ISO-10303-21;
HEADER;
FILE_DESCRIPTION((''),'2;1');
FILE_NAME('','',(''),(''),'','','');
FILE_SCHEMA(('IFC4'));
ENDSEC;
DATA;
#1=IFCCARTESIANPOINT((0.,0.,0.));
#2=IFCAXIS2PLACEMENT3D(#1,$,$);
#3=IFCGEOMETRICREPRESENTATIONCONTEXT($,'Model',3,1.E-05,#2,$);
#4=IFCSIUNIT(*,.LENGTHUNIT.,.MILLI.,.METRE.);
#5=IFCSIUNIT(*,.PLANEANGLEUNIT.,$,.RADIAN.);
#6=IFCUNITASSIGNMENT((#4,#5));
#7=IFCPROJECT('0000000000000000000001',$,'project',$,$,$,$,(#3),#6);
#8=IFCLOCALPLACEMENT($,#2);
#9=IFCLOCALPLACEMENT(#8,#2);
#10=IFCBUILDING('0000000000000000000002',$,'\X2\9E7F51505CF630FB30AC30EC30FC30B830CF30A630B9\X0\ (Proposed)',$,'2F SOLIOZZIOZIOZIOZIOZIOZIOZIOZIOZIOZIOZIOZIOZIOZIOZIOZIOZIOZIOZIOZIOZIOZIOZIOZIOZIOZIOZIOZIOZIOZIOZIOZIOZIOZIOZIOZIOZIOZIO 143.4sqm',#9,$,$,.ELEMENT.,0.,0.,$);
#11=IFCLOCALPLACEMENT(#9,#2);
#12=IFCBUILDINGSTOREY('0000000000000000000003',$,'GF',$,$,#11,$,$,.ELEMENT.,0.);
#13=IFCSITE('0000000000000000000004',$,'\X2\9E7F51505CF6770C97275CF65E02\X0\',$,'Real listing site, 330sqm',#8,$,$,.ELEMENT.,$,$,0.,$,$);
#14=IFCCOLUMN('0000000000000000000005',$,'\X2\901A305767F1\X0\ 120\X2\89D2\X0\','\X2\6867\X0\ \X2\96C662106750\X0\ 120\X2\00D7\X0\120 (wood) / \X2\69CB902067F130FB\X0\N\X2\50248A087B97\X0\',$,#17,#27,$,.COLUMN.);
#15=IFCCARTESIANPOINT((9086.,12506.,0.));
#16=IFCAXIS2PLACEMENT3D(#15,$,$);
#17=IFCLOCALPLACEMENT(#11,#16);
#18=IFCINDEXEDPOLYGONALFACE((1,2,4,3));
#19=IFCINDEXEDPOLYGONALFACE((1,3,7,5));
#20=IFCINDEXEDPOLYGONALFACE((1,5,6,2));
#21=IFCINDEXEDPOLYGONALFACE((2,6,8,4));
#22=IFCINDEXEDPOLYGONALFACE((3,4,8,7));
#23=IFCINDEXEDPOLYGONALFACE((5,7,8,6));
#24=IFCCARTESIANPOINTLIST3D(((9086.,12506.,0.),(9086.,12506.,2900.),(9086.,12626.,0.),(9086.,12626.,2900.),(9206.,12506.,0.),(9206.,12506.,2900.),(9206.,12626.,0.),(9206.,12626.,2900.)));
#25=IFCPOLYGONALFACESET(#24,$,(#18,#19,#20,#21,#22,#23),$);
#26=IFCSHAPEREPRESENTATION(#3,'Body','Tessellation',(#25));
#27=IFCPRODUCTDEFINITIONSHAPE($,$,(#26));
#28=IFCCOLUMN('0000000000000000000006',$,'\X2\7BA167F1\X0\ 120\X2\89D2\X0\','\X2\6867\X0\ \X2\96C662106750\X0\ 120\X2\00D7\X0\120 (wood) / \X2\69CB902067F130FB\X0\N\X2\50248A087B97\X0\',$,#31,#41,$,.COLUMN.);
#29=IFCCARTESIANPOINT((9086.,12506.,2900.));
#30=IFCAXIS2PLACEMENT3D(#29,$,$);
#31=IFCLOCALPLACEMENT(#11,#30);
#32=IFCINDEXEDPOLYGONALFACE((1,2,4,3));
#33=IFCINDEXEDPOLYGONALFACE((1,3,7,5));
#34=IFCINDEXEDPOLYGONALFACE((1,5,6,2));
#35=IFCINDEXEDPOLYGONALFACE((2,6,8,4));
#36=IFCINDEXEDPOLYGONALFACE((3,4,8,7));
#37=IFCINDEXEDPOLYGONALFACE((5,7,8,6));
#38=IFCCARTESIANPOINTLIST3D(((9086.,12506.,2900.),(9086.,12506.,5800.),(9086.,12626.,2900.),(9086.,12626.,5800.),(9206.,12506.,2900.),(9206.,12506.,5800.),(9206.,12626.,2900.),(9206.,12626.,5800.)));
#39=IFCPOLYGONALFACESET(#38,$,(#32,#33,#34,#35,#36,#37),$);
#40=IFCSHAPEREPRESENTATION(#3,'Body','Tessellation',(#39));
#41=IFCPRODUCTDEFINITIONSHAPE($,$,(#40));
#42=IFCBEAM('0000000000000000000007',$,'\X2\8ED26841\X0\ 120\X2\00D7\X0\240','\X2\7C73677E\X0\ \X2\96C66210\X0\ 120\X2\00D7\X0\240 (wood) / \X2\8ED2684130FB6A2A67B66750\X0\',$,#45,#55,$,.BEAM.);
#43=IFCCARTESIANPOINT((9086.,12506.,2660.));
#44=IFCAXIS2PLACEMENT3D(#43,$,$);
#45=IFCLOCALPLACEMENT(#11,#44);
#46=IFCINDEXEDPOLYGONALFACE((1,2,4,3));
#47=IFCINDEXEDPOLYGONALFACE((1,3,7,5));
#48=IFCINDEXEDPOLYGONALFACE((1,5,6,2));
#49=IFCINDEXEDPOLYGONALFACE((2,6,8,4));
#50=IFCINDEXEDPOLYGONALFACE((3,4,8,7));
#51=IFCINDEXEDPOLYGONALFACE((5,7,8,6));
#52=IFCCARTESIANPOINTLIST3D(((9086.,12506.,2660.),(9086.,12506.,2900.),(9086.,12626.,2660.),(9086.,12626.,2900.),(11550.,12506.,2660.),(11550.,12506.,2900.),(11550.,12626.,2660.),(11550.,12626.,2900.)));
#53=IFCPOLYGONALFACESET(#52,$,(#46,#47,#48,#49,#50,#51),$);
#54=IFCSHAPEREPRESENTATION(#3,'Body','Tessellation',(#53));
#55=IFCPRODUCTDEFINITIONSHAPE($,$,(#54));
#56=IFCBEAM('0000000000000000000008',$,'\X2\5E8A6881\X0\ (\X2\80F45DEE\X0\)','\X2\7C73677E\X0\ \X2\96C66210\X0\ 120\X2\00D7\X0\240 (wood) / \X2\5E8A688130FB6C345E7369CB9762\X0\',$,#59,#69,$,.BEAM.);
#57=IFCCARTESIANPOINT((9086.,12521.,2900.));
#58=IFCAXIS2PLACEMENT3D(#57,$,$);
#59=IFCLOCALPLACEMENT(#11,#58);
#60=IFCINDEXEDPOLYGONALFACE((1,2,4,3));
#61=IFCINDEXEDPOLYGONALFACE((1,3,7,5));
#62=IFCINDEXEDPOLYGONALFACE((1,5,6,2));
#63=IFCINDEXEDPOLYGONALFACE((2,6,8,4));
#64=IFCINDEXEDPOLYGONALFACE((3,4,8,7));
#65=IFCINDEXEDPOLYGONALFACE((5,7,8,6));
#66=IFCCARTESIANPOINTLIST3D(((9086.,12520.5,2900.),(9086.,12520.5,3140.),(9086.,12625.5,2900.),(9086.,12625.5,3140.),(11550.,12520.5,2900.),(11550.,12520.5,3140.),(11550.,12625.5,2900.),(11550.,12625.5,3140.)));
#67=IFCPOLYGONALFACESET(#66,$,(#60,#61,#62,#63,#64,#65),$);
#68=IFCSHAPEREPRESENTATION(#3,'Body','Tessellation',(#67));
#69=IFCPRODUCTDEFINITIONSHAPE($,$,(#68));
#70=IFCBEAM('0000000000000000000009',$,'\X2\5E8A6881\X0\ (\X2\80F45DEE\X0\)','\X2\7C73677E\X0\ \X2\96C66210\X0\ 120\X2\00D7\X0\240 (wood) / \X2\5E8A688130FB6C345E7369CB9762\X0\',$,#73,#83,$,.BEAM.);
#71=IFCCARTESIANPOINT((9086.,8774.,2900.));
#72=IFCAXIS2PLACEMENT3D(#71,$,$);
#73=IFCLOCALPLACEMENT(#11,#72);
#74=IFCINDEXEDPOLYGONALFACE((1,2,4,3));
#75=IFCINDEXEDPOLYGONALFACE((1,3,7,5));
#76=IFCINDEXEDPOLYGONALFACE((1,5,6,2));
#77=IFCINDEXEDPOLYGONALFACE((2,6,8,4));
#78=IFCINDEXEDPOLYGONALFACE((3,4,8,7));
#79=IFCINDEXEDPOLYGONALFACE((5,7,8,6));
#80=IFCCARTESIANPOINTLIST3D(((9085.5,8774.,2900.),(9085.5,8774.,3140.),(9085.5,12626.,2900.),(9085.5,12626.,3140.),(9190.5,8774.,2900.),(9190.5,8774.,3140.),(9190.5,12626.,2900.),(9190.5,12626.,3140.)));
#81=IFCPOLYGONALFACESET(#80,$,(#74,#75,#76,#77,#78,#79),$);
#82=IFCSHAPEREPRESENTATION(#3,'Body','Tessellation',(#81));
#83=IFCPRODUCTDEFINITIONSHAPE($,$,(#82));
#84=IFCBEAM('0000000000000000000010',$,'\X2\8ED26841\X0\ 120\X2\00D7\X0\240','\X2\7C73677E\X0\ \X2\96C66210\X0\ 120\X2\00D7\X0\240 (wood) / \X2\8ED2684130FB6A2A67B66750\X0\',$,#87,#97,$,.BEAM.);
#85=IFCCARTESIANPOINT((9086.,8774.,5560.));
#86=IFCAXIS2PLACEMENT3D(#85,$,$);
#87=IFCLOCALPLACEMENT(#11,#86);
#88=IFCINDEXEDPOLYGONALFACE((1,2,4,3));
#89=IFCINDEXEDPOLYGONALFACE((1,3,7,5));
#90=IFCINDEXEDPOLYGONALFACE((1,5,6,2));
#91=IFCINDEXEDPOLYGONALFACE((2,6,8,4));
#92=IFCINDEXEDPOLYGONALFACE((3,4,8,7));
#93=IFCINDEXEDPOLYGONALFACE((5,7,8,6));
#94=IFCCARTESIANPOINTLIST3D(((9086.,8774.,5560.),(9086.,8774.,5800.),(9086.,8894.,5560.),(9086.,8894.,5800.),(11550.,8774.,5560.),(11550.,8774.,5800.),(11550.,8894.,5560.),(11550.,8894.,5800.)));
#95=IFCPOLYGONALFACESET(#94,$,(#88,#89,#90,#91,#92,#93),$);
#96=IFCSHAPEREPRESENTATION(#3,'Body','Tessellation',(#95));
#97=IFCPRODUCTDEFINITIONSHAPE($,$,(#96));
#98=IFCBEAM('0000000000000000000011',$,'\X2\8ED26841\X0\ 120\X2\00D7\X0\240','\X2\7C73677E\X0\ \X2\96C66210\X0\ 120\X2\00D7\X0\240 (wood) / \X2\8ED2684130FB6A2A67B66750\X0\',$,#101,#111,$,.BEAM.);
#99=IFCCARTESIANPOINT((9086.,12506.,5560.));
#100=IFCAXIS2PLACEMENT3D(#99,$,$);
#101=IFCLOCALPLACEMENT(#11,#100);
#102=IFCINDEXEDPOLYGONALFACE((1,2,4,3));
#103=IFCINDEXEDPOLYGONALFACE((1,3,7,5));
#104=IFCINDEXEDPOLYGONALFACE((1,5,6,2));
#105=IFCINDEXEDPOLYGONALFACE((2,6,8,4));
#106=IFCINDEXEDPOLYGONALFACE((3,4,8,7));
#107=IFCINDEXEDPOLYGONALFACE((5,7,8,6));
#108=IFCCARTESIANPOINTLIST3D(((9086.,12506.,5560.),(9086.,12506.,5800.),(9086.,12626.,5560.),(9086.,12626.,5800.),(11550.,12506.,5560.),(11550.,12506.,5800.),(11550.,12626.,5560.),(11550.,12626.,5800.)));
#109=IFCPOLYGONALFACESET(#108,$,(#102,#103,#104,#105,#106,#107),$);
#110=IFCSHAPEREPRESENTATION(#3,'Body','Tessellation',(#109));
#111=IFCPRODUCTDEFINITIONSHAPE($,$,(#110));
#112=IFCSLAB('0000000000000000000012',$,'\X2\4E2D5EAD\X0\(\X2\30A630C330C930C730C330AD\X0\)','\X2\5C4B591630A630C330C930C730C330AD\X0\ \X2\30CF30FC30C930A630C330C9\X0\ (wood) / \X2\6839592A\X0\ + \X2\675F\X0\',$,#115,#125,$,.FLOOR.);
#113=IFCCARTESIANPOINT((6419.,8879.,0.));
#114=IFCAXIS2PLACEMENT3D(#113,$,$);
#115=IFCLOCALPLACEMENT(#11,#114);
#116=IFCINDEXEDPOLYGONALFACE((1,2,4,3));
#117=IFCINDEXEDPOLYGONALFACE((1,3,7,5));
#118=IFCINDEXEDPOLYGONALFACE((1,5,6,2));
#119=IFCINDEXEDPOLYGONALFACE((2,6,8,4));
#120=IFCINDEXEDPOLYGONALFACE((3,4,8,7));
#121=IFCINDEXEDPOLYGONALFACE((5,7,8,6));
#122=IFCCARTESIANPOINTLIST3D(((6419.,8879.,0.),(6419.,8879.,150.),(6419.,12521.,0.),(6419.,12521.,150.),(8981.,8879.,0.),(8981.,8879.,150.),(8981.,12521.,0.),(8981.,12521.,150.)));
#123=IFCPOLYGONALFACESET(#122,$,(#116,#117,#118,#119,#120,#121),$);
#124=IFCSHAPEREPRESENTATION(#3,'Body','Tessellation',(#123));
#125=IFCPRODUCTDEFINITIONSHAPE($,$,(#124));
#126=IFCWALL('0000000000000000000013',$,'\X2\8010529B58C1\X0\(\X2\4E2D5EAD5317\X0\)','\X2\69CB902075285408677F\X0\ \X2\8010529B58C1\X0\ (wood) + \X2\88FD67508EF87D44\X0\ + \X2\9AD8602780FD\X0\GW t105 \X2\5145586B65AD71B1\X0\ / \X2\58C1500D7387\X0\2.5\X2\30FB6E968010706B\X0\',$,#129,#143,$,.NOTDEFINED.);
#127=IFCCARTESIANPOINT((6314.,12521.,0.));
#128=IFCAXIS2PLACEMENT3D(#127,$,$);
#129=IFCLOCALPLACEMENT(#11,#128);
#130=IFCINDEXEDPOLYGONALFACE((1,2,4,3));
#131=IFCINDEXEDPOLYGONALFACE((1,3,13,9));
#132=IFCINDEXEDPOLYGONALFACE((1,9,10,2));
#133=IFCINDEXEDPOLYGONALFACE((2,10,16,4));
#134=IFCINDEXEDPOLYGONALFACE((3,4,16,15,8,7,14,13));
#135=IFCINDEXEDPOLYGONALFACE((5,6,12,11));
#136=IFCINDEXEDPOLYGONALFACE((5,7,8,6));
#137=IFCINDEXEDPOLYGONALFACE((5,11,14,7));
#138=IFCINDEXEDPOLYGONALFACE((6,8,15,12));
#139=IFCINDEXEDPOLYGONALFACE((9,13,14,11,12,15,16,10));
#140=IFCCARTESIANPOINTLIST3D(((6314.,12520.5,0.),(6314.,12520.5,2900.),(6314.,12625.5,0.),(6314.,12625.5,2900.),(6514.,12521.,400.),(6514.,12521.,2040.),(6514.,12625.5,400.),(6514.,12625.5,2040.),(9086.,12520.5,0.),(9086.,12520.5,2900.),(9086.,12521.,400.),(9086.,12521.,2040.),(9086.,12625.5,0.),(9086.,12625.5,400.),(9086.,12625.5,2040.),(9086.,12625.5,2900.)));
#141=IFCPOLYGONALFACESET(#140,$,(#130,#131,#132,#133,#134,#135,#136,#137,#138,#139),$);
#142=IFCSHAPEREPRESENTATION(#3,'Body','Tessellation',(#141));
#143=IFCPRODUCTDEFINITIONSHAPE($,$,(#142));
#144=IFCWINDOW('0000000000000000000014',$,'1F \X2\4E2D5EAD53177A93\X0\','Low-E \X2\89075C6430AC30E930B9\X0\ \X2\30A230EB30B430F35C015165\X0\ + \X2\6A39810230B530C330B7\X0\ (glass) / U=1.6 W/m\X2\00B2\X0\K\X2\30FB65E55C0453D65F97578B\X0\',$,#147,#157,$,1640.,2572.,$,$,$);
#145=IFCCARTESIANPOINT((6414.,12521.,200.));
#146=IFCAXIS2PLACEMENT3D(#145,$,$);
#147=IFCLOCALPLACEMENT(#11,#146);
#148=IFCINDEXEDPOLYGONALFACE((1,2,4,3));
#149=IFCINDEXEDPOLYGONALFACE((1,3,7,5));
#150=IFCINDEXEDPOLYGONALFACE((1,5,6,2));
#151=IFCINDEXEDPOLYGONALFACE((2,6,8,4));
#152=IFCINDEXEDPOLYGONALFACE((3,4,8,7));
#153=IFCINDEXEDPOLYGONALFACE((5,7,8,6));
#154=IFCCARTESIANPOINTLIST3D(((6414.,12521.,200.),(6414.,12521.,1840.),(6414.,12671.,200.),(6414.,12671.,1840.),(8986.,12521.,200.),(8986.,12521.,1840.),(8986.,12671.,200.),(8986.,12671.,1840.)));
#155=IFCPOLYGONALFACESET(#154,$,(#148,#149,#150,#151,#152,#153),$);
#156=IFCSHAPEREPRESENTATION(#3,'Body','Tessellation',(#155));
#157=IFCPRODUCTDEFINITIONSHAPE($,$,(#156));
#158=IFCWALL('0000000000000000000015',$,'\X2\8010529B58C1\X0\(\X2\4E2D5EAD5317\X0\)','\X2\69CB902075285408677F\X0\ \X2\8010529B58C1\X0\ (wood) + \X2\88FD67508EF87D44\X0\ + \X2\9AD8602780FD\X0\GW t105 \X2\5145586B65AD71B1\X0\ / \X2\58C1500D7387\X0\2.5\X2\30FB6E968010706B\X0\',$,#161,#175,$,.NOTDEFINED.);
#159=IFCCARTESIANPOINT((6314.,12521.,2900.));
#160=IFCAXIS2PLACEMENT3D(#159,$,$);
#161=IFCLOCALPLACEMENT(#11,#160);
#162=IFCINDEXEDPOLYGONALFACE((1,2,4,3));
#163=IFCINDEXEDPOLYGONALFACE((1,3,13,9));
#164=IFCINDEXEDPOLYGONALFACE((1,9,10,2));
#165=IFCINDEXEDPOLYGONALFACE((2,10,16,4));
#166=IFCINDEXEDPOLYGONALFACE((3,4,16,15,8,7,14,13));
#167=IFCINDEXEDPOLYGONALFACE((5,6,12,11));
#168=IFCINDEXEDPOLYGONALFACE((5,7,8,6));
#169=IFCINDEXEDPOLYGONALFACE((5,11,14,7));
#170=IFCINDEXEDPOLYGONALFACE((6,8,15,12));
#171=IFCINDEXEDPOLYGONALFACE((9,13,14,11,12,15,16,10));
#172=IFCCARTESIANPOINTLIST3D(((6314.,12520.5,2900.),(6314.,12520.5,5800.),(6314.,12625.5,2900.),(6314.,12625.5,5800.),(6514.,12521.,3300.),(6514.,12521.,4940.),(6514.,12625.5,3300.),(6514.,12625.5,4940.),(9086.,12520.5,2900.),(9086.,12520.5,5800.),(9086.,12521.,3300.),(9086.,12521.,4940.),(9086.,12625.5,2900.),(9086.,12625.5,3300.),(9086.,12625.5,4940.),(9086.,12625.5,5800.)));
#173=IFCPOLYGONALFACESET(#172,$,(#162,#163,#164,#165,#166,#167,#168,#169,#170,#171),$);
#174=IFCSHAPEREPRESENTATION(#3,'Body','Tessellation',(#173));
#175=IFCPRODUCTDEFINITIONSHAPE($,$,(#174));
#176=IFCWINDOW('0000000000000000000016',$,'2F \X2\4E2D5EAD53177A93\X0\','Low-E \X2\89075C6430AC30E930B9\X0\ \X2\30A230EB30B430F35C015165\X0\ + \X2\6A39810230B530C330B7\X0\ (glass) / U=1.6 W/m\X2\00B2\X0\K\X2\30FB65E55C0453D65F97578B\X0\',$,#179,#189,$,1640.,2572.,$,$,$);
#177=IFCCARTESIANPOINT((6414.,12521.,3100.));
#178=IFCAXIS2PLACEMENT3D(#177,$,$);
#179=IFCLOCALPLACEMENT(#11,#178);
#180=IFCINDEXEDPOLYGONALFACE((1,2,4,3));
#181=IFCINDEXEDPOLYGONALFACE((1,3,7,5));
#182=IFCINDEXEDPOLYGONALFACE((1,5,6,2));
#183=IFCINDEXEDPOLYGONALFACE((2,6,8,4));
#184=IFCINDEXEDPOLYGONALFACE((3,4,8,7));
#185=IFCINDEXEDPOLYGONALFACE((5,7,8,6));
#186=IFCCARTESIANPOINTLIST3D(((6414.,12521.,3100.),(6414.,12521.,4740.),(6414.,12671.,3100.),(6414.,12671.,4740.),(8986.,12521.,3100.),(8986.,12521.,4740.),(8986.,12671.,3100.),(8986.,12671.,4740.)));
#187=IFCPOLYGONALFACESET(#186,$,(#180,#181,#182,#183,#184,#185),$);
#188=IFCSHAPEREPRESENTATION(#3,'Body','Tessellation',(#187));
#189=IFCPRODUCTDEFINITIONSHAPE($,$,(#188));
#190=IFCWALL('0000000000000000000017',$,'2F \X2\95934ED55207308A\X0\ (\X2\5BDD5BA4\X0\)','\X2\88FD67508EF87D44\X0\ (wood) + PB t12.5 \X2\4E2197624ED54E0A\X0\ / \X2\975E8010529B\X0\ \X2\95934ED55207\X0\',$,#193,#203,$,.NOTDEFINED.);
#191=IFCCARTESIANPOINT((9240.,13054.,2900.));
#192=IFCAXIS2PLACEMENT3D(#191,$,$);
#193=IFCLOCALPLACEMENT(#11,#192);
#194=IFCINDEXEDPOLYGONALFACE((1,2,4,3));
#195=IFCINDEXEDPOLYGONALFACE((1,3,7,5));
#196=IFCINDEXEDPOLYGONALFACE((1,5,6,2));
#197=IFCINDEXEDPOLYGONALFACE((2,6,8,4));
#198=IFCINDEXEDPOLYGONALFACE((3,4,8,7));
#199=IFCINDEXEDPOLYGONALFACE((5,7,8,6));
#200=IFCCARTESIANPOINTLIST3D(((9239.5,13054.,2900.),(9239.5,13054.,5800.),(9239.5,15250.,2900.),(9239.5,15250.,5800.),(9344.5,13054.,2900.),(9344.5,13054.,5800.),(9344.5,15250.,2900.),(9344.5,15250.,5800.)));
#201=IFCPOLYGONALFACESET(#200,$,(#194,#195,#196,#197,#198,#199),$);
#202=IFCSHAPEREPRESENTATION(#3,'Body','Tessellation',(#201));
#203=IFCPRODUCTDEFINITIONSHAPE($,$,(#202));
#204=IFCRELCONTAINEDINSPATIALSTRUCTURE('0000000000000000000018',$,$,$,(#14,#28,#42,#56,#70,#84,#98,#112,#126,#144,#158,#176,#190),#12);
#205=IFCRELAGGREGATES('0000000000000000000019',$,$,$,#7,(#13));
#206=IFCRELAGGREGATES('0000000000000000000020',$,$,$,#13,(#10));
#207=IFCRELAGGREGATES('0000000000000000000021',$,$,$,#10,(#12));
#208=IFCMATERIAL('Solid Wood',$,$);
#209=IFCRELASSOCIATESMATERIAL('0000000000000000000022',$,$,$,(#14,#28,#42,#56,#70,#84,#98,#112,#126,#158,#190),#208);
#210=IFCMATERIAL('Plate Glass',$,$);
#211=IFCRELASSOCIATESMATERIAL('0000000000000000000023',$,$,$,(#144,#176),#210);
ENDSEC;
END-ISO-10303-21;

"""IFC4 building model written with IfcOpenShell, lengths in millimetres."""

from ifc_helpers import new_model, si_unit, frame, frame_2d, origin, place, context, project, spatial, rectangle, extrude, material, element, fill, save


model = new_model("IFC4")

# Units and contexts
model_context = context("Model", 3, precision=1e-05, world=origin())
ifc_project = project(units=[si_unit("LENGTHUNIT", "METRE", prefix="MILLI"), si_unit("PLANEANGLEUNIT", "RADIAN")], contexts=[model_context])

# Site, building, storey
site_placement = place(None, origin())
site = spatial("IfcSite", under=ifc_project, at=site_placement, Name="鹿児島県霧島市", ObjectType="Real listing site, 330sqm", CompositionType="ELEMENT", RefElevation=0.0)
building_placement = place(site_placement, origin())
building = spatial("IfcBuilding", under=site, at=building_placement, Name="鹿児島・ガレージハウス (Proposed)", ObjectType="2F SOLIOZZIOZIOZIOZIOZIOZIOZIOZIOZIOZIOZIOZIOZIOZIOZIOZIOZIOZIOZIOZIOZIOZIOZIOZIOZIOZIOZIOZIOZIOZIOZIOZIOZIOZIOZIOZIOZIOZIO 143.4sqm", CompositionType="ELEMENT", ElevationOfRefHeight=0.0, ElevationOfTerrain=0.0)
storey_placement = place(building_placement, origin())
storey = spatial("IfcBuildingStorey", under=building, at=storey_placement, Name="GF", CompositionType="ELEMENT", Elevation=0.0)

# Columns
ifc_material_1 = material(Name="Solid Wood")
column_1_placement = place(storey_placement, frame((9086.0, 12506.0, 0.0)))
element("IfcColumn", 1, at=column_1_placement, inside=storey, material=ifc_material_1, Name="通し柱 120角", Description="桧 集成材 120×120 (wood) / 構造柱・N値計算", PredefinedType="COLUMN", context=model_context, shape_type="SweptSolid", body=[
    extrude(rectangle(XDim=120.0, YDim=120.0, at=frame_2d((60.0, 60.0))), frame((9086.0, 12506.0, 0.0)), (0.0, 0.0, 1.0), 2900.0),
])
column_2_placement = place(storey_placement, frame((9086.0, 12506.0, 2900.0)))
element("IfcColumn", 2, at=column_2_placement, inside=storey, material=ifc_material_1, Name="管柱 120角", Description="桧 集成材 120×120 (wood) / 構造柱・N値計算", PredefinedType="COLUMN", context=model_context, shape_type="SweptSolid", body=[
    extrude(rectangle(XDim=120.0, YDim=120.0, at=frame_2d((60.0, 60.0))), frame((9086.0, 12506.0, 2900.0)), (0.0, 0.0, 1.0), 2900.0),
])

# Beams
beam_1_placement = place(storey_placement, frame((9086.0, 12506.0, 2660.0)))
element("IfcBeam", 3, at=beam_1_placement, inside=storey, material=ifc_material_1, Name="軒桁 120×240", Description="米松 集成 120×240 (wood) / 軒桁・横架材", PredefinedType="BEAM", context=model_context, shape_type="SweptSolid", body=[
    extrude(rectangle(XDim=2464.0, YDim=120.0, at=frame_2d((1232.0, 60.0))), frame((9086.0, 12506.0, 2660.0)), (0.0, 0.0, 1.0), 240.0),
])
beam_2_placement = place(storey_placement, frame((9086.0, 12521.0, 2900.0)))
element("IfcBeam", 4, at=beam_2_placement, inside=storey, material=ifc_material_1, Name="床梁 (胴差)", Description="米松 集成 120×240 (wood) / 床梁・水平構面", PredefinedType="BEAM", context=model_context, shape_type="SweptSolid", body=[
    extrude(rectangle(XDim=2464.0, YDim=105.0, at=frame_2d((1232.0, 52.0))), frame((9086.0, 12521.0, 2900.0)), (0.0, 0.0, 1.0), 240.0),
])
beam_3_placement = place(storey_placement, frame((9086.0, 8774.0, 2900.0)))
element("IfcBeam", 5, at=beam_3_placement, inside=storey, material=ifc_material_1, Name="床梁 (胴差)", Description="米松 集成 120×240 (wood) / 床梁・水平構面", PredefinedType="BEAM", context=model_context, shape_type="SweptSolid", body=[
    extrude(rectangle(XDim=105.0, YDim=3852.0, at=frame_2d((52.0, 1926.0))), frame((9086.0, 8774.0, 2900.0)), (0.0, 0.0, 1.0), 240.0),
])
beam_4_placement = place(storey_placement, frame((9086.0, 8774.0, 5560.0)))
element("IfcBeam", 6, at=beam_4_placement, inside=storey, material=ifc_material_1, Name="軒桁 120×240", Description="米松 集成 120×240 (wood) / 軒桁・横架材", PredefinedType="BEAM", context=model_context, shape_type="SweptSolid", body=[
    extrude(rectangle(XDim=2464.0, YDim=120.0, at=frame_2d((1232.0, 60.0))), frame((9086.0, 8774.0, 5560.0)), (0.0, 0.0, 1.0), 240.0),
])
beam_5_placement = place(storey_placement, frame((9086.0, 12506.0, 5560.0)))
element("IfcBeam", 7, at=beam_5_placement, inside=storey, material=ifc_material_1, Name="軒桁 120×240", Description="米松 集成 120×240 (wood) / 軒桁・横架材", PredefinedType="BEAM", context=model_context, shape_type="SweptSolid", body=[
    extrude(rectangle(XDim=2464.0, YDim=120.0, at=frame_2d((1232.0, 60.0))), frame((9086.0, 12506.0, 5560.0)), (0.0, 0.0, 1.0), 240.0),
])

# Slab
slab_placement = place(storey_placement, frame((6419.0, 8879.0, 0.0)))
element("IfcSlab", 8, at=slab_placement, inside=storey, material=ifc_material_1, Name="中庭(ウッドデッキ)", Description="屋外ウッドデッキ ハードウッド (wood) / 根太 + 束", PredefinedType="FLOOR", context=model_context, shape_type="SweptSolid", body=[
    extrude(rectangle(XDim=2562.0, YDim=3642.0, at=frame_2d((1281.0, 1821.0))), frame((6419.0, 8879.0, 0.0)), (0.0, 0.0, 1.0), 150.0),
])

# Wall, opening, window
wall_1_placement = place(storey_placement, frame((6314.0, 12521.0, 0.0)))
wall_1 = element("IfcWall", 9, at=wall_1_placement, inside=storey, material=ifc_material_1, Name="耐力壁(中庭北)", Description="構造用合板 耐力壁 (wood) + 製材軸組 + 高性能GW t105 充填断熱 / 壁倍率2.5・準耐火", PredefinedType="NOTDEFINED", context=model_context, shape_type="SweptSolid", body=[
    extrude(rectangle(XDim=2772.0, YDim=105.0, at=frame_2d((1386.0, 52.0))), frame((6314.0, 12521.0, 0.0)), (0.0, 0.0, 1.0), 2900.0),
])
opening_1_placement = place(storey_placement, frame((6414.0, 12521.0, 200.0)))
opening_1 = element("IfcOpeningElement", 10, at=opening_1_placement, cuts=wall_1, PredefinedType="NOTDEFINED", context=model_context, shape_type="SweptSolid", body=[
    extrude(rectangle(XDim=2572.0, YDim=150.0, at=frame_2d((1286.0, 75.0))), frame((6414.0, 12521.0, 200.0)), (0.0, 0.0, 1.0), 1640.0),
])
ifc_material_2 = material(Name="Plate Glass")
window_1_placement = place(storey_placement, frame((6414.0, 12521.0, 200.0)))
window_1 = element("IfcWindow", 11, at=window_1_placement, inside=storey, material=ifc_material_2, Name="1F 中庭北窓", Description="Low-E 複層ガラス アルゴン封入 + 樹脂サッシ (glass) / U=1.6 W/m²K・日射取得型", OverallHeight=1640.0, OverallWidth=2572.0, context=model_context, shape_type="SweptSolid", body=[
    extrude(rectangle(XDim=2572.0, YDim=150.0, at=frame_2d((1286.0, 75.0))), frame((6414.0, 12521.0, 200.0)), (0.0, 0.0, 1.0), 1640.0),
])
fill(opening_1, window_1)

# Wall, opening, window
wall_2_placement = place(storey_placement, frame((6314.0, 12521.0, 2900.0)))
wall_2 = element("IfcWall", 12, at=wall_2_placement, inside=storey, material=ifc_material_1, Name="耐力壁(中庭北)", Description="構造用合板 耐力壁 (wood) + 製材軸組 + 高性能GW t105 充填断熱 / 壁倍率2.5・準耐火", PredefinedType="NOTDEFINED", context=model_context, shape_type="SweptSolid", body=[
    extrude(rectangle(XDim=2772.0, YDim=105.0, at=frame_2d((1386.0, 52.0))), frame((6314.0, 12521.0, 2900.0)), (0.0, 0.0, 1.0), 2900.0),
])
opening_2_placement = place(storey_placement, frame((6414.0, 12521.0, 3100.0)))
opening_2 = element("IfcOpeningElement", 13, at=opening_2_placement, cuts=wall_2, PredefinedType="NOTDEFINED", context=model_context, shape_type="SweptSolid", body=[
    extrude(rectangle(XDim=2572.0, YDim=150.0, at=frame_2d((1286.0, 75.0))), frame((6414.0, 12521.0, 3100.0)), (0.0, 0.0, 1.0), 1640.0),
])
window_2_placement = place(storey_placement, frame((6414.0, 12521.0, 3100.0)))
window_2 = element("IfcWindow", 14, at=window_2_placement, inside=storey, material=ifc_material_2, Name="2F 中庭北窓", Description="Low-E 複層ガラス アルゴン封入 + 樹脂サッシ (glass) / U=1.6 W/m²K・日射取得型", OverallHeight=1640.0, OverallWidth=2572.0, context=model_context, shape_type="SweptSolid", body=[
    extrude(rectangle(XDim=2572.0, YDim=150.0, at=frame_2d((1286.0, 75.0))), frame((6414.0, 12521.0, 3100.0)), (0.0, 0.0, 1.0), 1640.0),
])
fill(opening_2, window_2)

# Wall
wall_3_placement = place(storey_placement, frame((9240.0, 13054.0, 2900.0)))
element("IfcWall", 15, at=wall_3_placement, inside=storey, material=ifc_material_1, Name="2F 間仕切り (寝室)", Description="製材軸組 (wood) + PB t12.5 両面仕上 / 非耐力 間仕切", PredefinedType="NOTDEFINED", context=model_context, shape_type="SweptSolid", body=[
    extrude(rectangle(XDim=105.0, YDim=2196.0, at=frame_2d((52.0, 1098.0))), frame((9240.0, 13054.0, 2900.0)), (0.0, 0.0, 1.0), 2900.0),
])

save(model, "model.ifc")
